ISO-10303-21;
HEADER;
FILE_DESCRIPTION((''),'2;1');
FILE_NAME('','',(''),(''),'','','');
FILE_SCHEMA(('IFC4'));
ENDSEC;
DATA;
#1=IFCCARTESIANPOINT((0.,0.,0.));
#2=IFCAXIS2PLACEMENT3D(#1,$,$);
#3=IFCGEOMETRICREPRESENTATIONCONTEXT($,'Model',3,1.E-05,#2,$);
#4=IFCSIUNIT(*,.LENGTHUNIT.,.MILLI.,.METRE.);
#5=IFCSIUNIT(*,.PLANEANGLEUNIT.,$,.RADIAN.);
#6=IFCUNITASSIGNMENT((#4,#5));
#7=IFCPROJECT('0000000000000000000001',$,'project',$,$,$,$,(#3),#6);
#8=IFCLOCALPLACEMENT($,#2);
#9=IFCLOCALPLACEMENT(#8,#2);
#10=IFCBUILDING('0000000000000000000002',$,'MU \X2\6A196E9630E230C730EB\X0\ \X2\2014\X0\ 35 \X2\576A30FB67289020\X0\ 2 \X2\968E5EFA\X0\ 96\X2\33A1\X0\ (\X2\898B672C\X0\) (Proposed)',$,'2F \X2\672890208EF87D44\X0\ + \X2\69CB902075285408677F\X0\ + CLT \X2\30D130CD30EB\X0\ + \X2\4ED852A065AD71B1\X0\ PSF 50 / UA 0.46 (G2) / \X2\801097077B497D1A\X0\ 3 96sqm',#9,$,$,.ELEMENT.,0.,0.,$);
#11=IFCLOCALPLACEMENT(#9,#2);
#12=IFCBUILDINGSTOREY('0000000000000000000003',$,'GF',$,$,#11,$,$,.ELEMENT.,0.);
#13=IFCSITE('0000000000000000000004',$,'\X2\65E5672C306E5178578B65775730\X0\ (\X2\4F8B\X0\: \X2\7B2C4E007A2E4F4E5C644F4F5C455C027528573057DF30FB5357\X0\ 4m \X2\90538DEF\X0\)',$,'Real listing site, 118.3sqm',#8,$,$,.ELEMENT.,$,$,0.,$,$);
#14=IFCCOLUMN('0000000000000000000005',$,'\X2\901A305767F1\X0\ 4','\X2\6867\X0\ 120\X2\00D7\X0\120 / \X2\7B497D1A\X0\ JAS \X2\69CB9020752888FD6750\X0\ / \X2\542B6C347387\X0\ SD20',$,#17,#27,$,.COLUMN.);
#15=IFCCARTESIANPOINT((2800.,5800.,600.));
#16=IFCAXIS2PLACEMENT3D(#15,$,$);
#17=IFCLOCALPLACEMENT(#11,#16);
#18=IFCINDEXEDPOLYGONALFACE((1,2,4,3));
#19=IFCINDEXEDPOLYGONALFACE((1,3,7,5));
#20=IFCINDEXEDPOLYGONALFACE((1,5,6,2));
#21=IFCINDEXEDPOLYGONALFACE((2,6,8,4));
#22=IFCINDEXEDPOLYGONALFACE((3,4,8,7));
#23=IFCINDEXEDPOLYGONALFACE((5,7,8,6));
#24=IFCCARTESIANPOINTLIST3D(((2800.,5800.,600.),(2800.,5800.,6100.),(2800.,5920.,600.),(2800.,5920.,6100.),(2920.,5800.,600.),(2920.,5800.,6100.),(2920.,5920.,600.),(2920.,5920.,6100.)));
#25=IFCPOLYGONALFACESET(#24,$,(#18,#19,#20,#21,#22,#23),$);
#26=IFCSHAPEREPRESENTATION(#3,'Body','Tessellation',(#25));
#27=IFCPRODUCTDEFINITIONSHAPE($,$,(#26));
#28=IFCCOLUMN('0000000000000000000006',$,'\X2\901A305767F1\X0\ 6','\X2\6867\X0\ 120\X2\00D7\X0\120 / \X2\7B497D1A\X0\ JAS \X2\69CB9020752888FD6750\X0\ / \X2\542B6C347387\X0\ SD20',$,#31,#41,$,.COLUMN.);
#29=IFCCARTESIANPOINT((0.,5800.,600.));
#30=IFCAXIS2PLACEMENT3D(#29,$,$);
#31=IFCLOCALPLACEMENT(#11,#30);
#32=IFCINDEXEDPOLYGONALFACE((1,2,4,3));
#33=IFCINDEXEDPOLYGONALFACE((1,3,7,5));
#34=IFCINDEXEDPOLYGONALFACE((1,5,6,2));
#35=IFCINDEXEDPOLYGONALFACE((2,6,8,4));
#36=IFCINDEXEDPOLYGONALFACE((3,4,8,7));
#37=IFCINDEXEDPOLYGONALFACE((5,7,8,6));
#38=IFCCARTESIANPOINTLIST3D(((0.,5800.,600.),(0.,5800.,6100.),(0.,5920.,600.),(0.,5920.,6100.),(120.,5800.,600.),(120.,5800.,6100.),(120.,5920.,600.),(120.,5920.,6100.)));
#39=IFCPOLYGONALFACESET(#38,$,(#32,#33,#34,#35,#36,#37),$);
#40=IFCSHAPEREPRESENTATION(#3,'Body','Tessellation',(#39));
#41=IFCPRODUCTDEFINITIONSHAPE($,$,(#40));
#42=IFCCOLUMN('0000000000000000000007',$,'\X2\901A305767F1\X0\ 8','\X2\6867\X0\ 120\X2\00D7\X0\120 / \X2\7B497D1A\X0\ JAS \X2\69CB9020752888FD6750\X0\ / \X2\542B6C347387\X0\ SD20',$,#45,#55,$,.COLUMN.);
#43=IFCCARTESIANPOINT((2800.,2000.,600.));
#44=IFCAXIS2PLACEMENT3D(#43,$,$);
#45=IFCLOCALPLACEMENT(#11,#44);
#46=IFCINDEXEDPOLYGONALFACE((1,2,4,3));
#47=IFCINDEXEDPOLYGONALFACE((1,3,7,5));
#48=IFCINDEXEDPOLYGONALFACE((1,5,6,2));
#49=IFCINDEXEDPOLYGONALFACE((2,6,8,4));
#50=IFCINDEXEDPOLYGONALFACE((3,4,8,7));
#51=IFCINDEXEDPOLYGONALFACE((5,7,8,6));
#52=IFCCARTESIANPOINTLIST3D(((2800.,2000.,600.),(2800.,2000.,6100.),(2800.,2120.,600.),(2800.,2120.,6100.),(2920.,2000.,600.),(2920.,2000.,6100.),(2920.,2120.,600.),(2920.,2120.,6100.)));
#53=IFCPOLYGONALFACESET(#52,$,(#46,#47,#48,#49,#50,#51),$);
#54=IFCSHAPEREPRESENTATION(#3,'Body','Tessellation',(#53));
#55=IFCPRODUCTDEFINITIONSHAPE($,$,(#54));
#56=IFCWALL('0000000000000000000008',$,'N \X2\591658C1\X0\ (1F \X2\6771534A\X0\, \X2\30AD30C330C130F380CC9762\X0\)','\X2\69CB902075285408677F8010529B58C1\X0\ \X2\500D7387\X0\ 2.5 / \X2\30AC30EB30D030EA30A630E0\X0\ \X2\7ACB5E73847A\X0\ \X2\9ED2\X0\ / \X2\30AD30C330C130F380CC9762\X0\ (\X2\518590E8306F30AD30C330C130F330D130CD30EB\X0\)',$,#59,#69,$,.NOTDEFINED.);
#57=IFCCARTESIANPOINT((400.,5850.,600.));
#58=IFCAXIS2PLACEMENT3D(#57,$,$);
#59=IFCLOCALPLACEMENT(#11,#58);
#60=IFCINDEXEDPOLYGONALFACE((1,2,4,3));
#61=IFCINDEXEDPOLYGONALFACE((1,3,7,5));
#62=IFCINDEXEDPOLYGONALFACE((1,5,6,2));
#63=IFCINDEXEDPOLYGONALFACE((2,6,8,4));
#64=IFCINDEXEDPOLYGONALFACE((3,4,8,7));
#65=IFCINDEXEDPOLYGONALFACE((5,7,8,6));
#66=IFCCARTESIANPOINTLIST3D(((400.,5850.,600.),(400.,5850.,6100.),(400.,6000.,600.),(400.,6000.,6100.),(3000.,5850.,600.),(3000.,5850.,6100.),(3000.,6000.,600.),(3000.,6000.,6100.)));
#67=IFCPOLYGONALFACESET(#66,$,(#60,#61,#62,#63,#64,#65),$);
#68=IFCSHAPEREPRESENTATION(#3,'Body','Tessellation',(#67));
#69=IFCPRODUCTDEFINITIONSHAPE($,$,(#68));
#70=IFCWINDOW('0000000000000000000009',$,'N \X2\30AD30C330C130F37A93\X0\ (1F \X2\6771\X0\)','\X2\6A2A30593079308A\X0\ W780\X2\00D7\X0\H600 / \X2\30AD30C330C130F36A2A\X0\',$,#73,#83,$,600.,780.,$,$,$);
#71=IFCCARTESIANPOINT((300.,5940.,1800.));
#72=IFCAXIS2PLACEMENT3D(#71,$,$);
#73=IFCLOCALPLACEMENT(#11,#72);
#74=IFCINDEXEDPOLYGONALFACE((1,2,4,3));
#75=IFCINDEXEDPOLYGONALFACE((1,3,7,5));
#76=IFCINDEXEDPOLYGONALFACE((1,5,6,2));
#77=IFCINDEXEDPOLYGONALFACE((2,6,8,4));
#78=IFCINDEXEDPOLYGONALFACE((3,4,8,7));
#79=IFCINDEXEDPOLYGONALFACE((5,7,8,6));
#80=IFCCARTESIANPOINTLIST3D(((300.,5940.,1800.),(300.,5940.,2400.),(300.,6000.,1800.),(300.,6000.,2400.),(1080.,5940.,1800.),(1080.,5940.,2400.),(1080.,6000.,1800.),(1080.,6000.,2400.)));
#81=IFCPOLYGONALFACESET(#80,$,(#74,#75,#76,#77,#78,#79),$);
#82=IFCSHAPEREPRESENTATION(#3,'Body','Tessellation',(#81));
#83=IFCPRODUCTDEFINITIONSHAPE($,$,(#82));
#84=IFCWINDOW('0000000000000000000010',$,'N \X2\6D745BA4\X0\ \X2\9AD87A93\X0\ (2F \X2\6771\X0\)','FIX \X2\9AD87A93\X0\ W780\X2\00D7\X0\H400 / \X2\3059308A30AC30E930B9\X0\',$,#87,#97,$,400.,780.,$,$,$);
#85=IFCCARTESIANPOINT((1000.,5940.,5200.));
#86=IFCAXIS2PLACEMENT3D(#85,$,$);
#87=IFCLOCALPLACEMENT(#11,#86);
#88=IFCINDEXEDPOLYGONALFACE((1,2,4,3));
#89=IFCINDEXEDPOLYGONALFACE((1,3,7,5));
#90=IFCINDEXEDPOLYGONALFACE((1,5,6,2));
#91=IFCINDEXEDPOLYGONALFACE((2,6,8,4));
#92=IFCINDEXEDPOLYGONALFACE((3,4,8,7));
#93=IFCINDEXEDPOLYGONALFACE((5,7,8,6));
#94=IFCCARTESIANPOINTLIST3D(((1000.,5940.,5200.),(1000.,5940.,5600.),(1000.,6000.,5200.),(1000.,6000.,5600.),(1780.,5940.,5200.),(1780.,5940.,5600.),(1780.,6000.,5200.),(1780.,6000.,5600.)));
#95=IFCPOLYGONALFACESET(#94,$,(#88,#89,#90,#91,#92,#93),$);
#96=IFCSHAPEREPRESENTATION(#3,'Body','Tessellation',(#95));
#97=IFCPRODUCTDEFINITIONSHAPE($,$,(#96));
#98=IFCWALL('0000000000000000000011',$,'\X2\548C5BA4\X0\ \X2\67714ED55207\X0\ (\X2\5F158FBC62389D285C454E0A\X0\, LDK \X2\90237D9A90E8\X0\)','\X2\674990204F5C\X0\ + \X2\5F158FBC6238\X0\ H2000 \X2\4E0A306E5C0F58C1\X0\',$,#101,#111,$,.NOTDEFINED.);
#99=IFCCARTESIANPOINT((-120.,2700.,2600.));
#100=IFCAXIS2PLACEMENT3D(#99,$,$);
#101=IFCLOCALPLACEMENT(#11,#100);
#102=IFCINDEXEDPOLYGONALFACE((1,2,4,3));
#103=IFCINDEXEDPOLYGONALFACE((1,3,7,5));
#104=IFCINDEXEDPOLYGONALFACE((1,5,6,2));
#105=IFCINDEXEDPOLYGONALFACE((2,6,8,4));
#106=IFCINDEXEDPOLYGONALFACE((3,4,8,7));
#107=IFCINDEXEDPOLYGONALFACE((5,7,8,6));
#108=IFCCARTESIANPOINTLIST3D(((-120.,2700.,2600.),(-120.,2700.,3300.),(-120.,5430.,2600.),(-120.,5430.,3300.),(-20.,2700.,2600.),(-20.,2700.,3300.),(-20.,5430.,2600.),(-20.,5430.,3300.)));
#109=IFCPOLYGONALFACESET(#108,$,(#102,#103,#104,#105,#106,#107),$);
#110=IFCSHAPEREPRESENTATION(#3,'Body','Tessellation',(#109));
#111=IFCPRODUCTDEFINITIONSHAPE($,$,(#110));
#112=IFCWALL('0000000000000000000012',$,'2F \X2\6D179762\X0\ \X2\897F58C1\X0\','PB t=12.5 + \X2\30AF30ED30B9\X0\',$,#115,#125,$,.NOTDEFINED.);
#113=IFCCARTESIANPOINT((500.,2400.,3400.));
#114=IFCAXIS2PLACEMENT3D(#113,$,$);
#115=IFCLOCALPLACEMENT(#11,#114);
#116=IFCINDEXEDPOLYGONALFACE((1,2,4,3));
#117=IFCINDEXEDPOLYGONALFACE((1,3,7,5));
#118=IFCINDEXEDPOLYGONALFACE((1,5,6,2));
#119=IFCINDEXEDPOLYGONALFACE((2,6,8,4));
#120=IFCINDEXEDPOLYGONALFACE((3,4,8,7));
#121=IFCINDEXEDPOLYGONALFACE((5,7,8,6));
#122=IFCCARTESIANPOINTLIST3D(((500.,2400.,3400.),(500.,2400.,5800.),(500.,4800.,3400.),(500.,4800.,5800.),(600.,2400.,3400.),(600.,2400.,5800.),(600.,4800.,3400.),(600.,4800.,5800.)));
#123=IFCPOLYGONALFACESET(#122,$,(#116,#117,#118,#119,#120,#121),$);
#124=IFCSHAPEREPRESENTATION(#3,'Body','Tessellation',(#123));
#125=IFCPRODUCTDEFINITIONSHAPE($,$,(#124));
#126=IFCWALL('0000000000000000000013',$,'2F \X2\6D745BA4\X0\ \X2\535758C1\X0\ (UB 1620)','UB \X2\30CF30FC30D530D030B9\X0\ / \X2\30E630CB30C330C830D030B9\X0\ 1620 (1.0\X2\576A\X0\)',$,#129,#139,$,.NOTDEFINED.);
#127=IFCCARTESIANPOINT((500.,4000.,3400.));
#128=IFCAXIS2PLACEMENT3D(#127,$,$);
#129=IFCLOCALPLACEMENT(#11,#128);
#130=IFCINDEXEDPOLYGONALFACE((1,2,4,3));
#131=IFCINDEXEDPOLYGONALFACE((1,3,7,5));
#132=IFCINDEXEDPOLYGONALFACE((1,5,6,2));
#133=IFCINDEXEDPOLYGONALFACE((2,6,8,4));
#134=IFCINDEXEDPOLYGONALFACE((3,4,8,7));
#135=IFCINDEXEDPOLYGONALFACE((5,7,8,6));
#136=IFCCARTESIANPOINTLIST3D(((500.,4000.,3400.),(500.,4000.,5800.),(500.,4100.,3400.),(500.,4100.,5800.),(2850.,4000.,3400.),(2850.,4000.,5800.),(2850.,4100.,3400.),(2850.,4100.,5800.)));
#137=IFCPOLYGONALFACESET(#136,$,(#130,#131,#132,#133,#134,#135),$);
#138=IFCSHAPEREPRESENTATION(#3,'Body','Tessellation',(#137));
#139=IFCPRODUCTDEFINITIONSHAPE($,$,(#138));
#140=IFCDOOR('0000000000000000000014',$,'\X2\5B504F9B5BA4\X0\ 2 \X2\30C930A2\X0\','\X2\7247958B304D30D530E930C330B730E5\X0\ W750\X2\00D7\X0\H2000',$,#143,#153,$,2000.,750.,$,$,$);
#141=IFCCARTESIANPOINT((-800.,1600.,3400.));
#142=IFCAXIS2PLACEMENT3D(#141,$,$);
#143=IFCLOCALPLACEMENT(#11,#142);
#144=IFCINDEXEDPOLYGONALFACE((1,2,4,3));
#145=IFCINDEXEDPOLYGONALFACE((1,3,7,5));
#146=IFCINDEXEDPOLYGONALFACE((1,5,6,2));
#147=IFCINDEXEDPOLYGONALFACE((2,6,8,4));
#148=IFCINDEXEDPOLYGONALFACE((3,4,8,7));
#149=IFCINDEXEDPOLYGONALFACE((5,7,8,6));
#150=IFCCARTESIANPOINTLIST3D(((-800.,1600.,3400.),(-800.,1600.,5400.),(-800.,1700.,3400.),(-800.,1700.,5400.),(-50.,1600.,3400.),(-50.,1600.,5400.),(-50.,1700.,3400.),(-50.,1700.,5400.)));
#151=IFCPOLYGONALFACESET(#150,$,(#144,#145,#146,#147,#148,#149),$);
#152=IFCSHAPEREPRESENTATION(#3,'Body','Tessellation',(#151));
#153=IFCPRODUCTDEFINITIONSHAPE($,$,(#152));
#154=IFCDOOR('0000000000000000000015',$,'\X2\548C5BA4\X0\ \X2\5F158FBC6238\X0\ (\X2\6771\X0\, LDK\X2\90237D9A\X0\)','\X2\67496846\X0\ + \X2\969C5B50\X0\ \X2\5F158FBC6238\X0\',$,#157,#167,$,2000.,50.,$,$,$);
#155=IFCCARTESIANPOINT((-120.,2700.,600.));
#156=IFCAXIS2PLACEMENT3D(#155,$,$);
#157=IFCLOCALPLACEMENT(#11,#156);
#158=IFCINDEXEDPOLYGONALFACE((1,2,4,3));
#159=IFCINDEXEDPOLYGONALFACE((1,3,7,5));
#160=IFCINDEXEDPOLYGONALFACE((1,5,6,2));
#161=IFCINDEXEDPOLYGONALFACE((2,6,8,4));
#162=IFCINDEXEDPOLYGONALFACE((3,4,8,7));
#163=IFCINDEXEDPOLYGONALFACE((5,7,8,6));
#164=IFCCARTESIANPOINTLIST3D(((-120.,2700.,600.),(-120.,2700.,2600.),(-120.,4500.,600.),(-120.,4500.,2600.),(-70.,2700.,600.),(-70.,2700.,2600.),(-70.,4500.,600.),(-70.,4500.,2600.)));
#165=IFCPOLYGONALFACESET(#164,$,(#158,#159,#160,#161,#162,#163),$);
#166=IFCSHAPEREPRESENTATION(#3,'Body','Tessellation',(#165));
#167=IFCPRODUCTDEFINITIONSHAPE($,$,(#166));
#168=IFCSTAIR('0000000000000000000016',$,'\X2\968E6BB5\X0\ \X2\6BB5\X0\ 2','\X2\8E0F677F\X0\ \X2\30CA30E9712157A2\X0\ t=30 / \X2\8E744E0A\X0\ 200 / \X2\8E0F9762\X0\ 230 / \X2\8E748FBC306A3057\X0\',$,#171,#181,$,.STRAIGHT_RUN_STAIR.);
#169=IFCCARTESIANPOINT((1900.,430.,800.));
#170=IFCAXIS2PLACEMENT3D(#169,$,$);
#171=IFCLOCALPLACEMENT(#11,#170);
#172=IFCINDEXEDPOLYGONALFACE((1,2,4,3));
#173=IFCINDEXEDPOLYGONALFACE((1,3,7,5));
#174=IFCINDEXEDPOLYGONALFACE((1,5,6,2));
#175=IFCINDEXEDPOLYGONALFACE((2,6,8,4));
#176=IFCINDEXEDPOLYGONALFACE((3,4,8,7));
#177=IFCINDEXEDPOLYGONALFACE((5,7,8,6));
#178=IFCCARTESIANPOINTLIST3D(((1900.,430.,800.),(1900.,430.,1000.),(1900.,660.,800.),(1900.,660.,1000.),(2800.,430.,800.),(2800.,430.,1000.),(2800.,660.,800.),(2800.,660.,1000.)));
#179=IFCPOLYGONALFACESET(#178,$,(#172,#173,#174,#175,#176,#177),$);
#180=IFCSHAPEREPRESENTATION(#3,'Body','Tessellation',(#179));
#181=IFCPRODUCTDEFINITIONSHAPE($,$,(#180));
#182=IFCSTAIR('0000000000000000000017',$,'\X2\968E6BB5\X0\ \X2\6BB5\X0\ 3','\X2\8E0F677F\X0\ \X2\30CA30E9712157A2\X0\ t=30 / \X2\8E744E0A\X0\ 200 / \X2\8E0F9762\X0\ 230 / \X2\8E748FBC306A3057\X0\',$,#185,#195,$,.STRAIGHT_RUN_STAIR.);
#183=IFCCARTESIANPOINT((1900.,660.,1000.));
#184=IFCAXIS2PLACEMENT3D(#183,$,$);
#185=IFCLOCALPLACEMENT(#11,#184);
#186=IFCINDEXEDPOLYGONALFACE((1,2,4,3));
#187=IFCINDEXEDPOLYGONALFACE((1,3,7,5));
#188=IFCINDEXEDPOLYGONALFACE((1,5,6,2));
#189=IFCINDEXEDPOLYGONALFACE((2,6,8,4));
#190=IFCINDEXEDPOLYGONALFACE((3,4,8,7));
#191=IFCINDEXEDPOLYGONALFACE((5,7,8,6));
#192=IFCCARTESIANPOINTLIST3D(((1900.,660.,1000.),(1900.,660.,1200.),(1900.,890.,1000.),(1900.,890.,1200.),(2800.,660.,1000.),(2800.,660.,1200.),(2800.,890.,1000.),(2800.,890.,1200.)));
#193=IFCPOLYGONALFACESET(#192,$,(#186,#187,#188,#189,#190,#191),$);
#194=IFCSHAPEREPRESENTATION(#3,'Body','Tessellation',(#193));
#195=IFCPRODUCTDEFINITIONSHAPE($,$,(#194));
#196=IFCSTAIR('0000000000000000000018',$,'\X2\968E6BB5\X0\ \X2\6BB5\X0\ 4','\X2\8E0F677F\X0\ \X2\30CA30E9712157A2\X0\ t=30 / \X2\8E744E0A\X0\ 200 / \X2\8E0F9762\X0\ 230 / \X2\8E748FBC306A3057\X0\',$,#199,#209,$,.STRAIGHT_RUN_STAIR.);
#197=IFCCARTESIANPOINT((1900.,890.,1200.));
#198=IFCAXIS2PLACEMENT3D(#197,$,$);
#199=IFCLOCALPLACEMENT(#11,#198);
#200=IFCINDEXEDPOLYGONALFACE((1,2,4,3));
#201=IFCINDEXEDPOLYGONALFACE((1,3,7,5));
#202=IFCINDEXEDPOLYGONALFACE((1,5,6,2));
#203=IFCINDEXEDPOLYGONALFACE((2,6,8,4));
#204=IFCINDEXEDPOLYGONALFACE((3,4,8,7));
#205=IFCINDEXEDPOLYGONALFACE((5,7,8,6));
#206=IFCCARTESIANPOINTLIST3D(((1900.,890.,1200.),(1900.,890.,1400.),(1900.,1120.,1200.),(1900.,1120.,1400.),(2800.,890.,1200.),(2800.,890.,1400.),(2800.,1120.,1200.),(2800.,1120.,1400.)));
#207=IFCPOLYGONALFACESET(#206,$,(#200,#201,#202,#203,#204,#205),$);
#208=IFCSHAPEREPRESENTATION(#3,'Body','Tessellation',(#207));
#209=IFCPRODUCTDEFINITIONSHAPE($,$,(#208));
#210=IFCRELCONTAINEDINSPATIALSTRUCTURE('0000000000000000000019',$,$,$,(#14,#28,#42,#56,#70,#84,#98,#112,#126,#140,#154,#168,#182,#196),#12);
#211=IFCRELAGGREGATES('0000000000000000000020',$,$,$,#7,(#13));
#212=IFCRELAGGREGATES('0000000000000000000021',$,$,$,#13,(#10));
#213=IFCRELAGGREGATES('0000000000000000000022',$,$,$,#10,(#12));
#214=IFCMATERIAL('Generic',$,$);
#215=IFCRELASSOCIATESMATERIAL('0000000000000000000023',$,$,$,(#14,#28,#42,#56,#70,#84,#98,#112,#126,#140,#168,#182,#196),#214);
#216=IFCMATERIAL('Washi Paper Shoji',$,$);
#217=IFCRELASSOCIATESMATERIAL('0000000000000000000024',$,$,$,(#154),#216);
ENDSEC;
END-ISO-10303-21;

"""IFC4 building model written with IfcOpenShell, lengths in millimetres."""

from ifc_helpers import new_model, si_unit, frame, frame_2d, origin, place, context, project, spatial, rectangle, extrude, material, element, fill, save


model = new_model("IFC4")

# Units and contexts
model_context = context("Model", 3, precision=1e-05, world=origin())
ifc_project = project(units=[si_unit("LENGTHUNIT", "METRE", prefix="MILLI"), si_unit("PLANEANGLEUNIT", "RADIAN")], contexts=[model_context])

# Site, building, storey
site_placement = place(None, origin())
site = spatial("IfcSite", under=ifc_project, at=site_placement, Name="日本の典型敷地 (例: 第一種低層住居専用地域・南 4m 道路)", ObjectType="Real listing site, 118.3sqm", CompositionType="ELEMENT", RefElevation=0.0)
building_placement = place(site_placement, origin())
building = spatial("IfcBuilding", under=site, at=building_placement, Name="MU 標準モデル — 35 坪・木造 2 階建 96㎡ (見本) (Proposed)", ObjectType="2F 木造軸組 + 構造用合板 + CLT パネル + 付加断熱 PSF 50 / UA 0.46 (G2) / 耐震等級 3 96sqm", CompositionType="ELEMENT", ElevationOfRefHeight=0.0, ElevationOfTerrain=0.0)
storey_placement = place(building_placement, origin())
storey = spatial("IfcBuildingStorey", under=building, at=storey_placement, Name="GF", CompositionType="ELEMENT", Elevation=0.0)

# Columns
ifc_material_1 = material(Name="Generic")
column_1_placement = place(storey_placement, frame((2800.0, 5800.0, 600.0)))
element("IfcColumn", 1, at=column_1_placement, inside=storey, material=ifc_material_1, Name="通し柱 4", Description="桧 120×120 / 等級 JAS 構造用製材 / 含水率 SD20", PredefinedType="COLUMN", context=model_context, shape_type="SweptSolid", body=[
    extrude(rectangle(XDim=120.0, YDim=120.0, at=frame_2d((60.0, 60.0))), frame((2800.0, 5800.0, 600.0)), (0.0, 0.0, 1.0), 5500.0),
])
column_2_placement = place(storey_placement, frame((0.0, 5800.0, 600.0)))
element("IfcColumn", 2, at=column_2_placement, inside=storey, material=ifc_material_1, Name="通し柱 6", Description="桧 120×120 / 等級 JAS 構造用製材 / 含水率 SD20", PredefinedType="COLUMN", context=model_context, shape_type="SweptSolid", body=[
    extrude(rectangle(XDim=120.0, YDim=120.0, at=frame_2d((60.0, 60.0))), frame((0.0, 5800.0, 600.0)), (0.0, 0.0, 1.0), 5500.0),
])
column_3_placement = place(storey_placement, frame((2800.0, 2000.0, 600.0)))
element("IfcColumn", 3, at=column_3_placement, inside=storey, material=ifc_material_1, Name="通し柱 8", Description="桧 120×120 / 等級 JAS 構造用製材 / 含水率 SD20", PredefinedType="COLUMN", context=model_context, shape_type="SweptSolid", body=[
    extrude(rectangle(XDim=120.0, YDim=120.0, at=frame_2d((60.0, 60.0))), frame((2800.0, 2000.0, 600.0)), (0.0, 0.0, 1.0), 5500.0),
])

# Wall, openings, windows
wall_1_placement = place(storey_placement, frame((400.0, 5850.0, 600.0)))
wall_1 = element("IfcWall", 4, at=wall_1_placement, inside=storey, material=ifc_material_1, Name="N 外壁 (1F 東半, キッチン背面)", Description="構造用合板耐力壁 倍率 2.5 / ガルバリウム 立平葺 黒 / キッチン背面 (内部はキッチンパネル)", PredefinedType="NOTDEFINED", context=model_context, shape_type="SweptSolid", body=[
    extrude(rectangle(XDim=2600.0, YDim=150.0, at=frame_2d((1300.0, 75.0))), frame((400.0, 5850.0, 600.0)), (0.0, 0.0, 1.0), 5500.0),
])
opening_1_placement = place(storey_placement, frame((300.0, 5940.0, 1800.0)))
opening_1 = element("IfcOpeningElement", 5, at=opening_1_placement, cuts=wall_1, PredefinedType="NOTDEFINED", context=model_context, shape_type="SweptSolid", body=[
    extrude(rectangle(XDim=780.0, YDim=60.0, at=frame_2d((390.0, 30.0))), frame((300.0, 5940.0, 1800.0)), (0.0, 0.0, 1.0), 600.0),
])
opening_2_placement = place(storey_placement, frame((1000.0, 5940.0, 5200.0)))
opening_2 = element("IfcOpeningElement", 6, at=opening_2_placement, cuts=wall_1, PredefinedType="NOTDEFINED", context=model_context, shape_type="SweptSolid", body=[
    extrude(rectangle(XDim=780.0, YDim=60.0, at=frame_2d((390.0, 30.0))), frame((1000.0, 5940.0, 5200.0)), (0.0, 0.0, 1.0), 400.0),
])
window_1_placement = place(storey_placement, frame((300.0, 5940.0, 1800.0)))
window_1 = element("IfcWindow", 7, at=window_1_placement, inside=storey, material=ifc_material_1, Name="N キッチン窓 (1F 東)", Description="横すべり W780×H600 / キッチン横", OverallHeight=600.0, OverallWidth=780.0, context=model_context, shape_type="SweptSolid", body=[
    extrude(rectangle(XDim=780.0, YDim=60.0, at=frame_2d((390.0, 30.0))), frame((300.0, 5940.0, 1800.0)), (0.0, 0.0, 1.0), 600.0),
])
fill(opening_1, window_1)
window_2_placement = place(storey_placement, frame((1000.0, 5940.0, 5200.0)))
window_2 = element("IfcWindow", 8, at=window_2_placement, inside=storey, material=ifc_material_1, Name="N 浴室 高窓 (2F 東)", Description="FIX 高窓 W780×H400 / すりガラス", OverallHeight=400.0, OverallWidth=780.0, context=model_context, shape_type="SweptSolid", body=[
    extrude(rectangle(XDim=780.0, YDim=60.0, at=frame_2d((390.0, 30.0))), frame((1000.0, 5940.0, 5200.0)), (0.0, 0.0, 1.0), 400.0),
])
fill(opening_2, window_2)

# Walls
wall_2_placement = place(storey_placement, frame((-120.0, 2700.0, 2600.0)))
element("IfcWall", 9, at=wall_2_placement, inside=storey, material=ifc_material_1, Name="和室 東仕切 (引込戸鴨居上, LDK 連続部)", Description="杉造作 + 引込戸 H2000 上の小壁", PredefinedType="NOTDEFINED", context=model_context, shape_type="SweptSolid", body=[
    extrude(rectangle(XDim=100.0, YDim=2730.0, at=frame_2d((50.0, 1365.0))), frame((-120.0, 2700.0, 2600.0)), (0.0, 0.0, 1.0), 700.0),
])
wall_3_placement = place(storey_placement, frame((500.0, 2400.0, 3400.0)))
element("IfcWall", 10, at=wall_3_placement, inside=storey, material=ifc_material_1, Name="2F 洗面 西壁", Description="PB t=12.5 + クロス", PredefinedType="NOTDEFINED", context=model_context, shape_type="SweptSolid", body=[
    extrude(rectangle(XDim=100.0, YDim=2400.0, at=frame_2d((50.0, 1200.0))), frame((500.0, 2400.0, 3400.0)), (0.0, 0.0, 1.0), 2400.0),
])
wall_4_placement = place(storey_placement, frame((500.0, 4000.0, 3400.0)))
element("IfcWall", 11, at=wall_4_placement, inside=storey, material=ifc_material_1, Name="2F 浴室 南壁 (UB 1620)", Description="UB ハーフバス / ユニットバス 1620 (1.0坪)", PredefinedType="NOTDEFINED", context=model_context, shape_type="SweptSolid", body=[
    extrude(rectangle(XDim=2350.0, YDim=100.0, at=frame_2d((1175.0, 50.0))), frame((500.0, 4000.0, 3400.0)), (0.0, 0.0, 1.0), 2400.0),
])

# Doors
door_1_placement = place(storey_placement, frame((-800.0, 1600.0, 3400.0)))
element("IfcDoor", 12, at=door_1_placement, inside=storey, material=ifc_material_1, Name="子供室 2 ドア", Description="片開きフラッシュ W750×H2000", OverallHeight=2000.0, OverallWidth=750.0, context=model_context, shape_type="SweptSolid", body=[
    extrude(rectangle(XDim=750.0, YDim=100.0, at=frame_2d((375.0, 50.0))), frame((-800.0, 1600.0, 3400.0)), (0.0, 0.0, 1.0), 2000.0),
])
ifc_material_2 = material(Name="Washi Paper Shoji")
door_2_placement = place(storey_placement, frame((-120.0, 2700.0, 600.0)))
element("IfcDoor", 13, at=door_2_placement, inside=storey, material=ifc_material_2, Name="和室 引込戸 (東, LDK連続)", Description="杉框 + 障子 引込戸", OverallHeight=2000.0, OverallWidth=50.0, context=model_context, shape_type="SweptSolid", body=[
    extrude(rectangle(XDim=50.0, YDim=1800.0, at=frame_2d((25.0, 900.0))), frame((-120.0, 2700.0, 600.0)), (0.0, 0.0, 1.0), 2000.0),
])

# Stairs
stair_1_placement = place(storey_placement, frame((1900.0, 430.0, 800.0)))
element("IfcStair", 14, at=stair_1_placement, inside=storey, material=ifc_material_1, Name="階段 段 2", Description="踏板 ナラ無垢 t=30 / 蹴上 200 / 踏面 230 / 蹴込なし", PredefinedType="STRAIGHT_RUN_STAIR", context=model_context, shape_type="SweptSolid", body=[
    extrude(rectangle(XDim=900.0, YDim=230.0, at=frame_2d((450.0, 115.0))), frame((1900.0, 430.0, 800.0)), (0.0, 0.0, 1.0), 200.0),
])
stair_2_placement = place(storey_placement, frame((1900.0, 660.0, 1000.0)))
element("IfcStair", 15, at=stair_2_placement, inside=storey, material=ifc_material_1, Name="階段 段 3", Description="踏板 ナラ無垢 t=30 / 蹴上 200 / 踏面 230 / 蹴込なし", PredefinedType="STRAIGHT_RUN_STAIR", context=model_context, shape_type="SweptSolid", body=[
    extrude(rectangle(XDim=900.0, YDim=230.0, at=frame_2d((450.0, 115.0))), frame((1900.0, 660.0, 1000.0)), (0.0, 0.0, 1.0), 200.0),
])
stair_3_placement = place(storey_placement, frame((1900.0, 890.0, 1200.0)))
element("IfcStair", 16, at=stair_3_placement, inside=storey, material=ifc_material_1, Name="階段 段 4", Description="踏板 ナラ無垢 t=30 / 蹴上 200 / 踏面 230 / 蹴込なし", PredefinedType="STRAIGHT_RUN_STAIR", context=model_context, shape_type="SweptSolid", body=[
    extrude(rectangle(XDim=900.0, YDim=230.0, at=frame_2d((450.0, 115.0))), frame((1900.0, 890.0, 1200.0)), (0.0, 0.0, 1.0), 200.0),
])

save(model, "model.ifc")
